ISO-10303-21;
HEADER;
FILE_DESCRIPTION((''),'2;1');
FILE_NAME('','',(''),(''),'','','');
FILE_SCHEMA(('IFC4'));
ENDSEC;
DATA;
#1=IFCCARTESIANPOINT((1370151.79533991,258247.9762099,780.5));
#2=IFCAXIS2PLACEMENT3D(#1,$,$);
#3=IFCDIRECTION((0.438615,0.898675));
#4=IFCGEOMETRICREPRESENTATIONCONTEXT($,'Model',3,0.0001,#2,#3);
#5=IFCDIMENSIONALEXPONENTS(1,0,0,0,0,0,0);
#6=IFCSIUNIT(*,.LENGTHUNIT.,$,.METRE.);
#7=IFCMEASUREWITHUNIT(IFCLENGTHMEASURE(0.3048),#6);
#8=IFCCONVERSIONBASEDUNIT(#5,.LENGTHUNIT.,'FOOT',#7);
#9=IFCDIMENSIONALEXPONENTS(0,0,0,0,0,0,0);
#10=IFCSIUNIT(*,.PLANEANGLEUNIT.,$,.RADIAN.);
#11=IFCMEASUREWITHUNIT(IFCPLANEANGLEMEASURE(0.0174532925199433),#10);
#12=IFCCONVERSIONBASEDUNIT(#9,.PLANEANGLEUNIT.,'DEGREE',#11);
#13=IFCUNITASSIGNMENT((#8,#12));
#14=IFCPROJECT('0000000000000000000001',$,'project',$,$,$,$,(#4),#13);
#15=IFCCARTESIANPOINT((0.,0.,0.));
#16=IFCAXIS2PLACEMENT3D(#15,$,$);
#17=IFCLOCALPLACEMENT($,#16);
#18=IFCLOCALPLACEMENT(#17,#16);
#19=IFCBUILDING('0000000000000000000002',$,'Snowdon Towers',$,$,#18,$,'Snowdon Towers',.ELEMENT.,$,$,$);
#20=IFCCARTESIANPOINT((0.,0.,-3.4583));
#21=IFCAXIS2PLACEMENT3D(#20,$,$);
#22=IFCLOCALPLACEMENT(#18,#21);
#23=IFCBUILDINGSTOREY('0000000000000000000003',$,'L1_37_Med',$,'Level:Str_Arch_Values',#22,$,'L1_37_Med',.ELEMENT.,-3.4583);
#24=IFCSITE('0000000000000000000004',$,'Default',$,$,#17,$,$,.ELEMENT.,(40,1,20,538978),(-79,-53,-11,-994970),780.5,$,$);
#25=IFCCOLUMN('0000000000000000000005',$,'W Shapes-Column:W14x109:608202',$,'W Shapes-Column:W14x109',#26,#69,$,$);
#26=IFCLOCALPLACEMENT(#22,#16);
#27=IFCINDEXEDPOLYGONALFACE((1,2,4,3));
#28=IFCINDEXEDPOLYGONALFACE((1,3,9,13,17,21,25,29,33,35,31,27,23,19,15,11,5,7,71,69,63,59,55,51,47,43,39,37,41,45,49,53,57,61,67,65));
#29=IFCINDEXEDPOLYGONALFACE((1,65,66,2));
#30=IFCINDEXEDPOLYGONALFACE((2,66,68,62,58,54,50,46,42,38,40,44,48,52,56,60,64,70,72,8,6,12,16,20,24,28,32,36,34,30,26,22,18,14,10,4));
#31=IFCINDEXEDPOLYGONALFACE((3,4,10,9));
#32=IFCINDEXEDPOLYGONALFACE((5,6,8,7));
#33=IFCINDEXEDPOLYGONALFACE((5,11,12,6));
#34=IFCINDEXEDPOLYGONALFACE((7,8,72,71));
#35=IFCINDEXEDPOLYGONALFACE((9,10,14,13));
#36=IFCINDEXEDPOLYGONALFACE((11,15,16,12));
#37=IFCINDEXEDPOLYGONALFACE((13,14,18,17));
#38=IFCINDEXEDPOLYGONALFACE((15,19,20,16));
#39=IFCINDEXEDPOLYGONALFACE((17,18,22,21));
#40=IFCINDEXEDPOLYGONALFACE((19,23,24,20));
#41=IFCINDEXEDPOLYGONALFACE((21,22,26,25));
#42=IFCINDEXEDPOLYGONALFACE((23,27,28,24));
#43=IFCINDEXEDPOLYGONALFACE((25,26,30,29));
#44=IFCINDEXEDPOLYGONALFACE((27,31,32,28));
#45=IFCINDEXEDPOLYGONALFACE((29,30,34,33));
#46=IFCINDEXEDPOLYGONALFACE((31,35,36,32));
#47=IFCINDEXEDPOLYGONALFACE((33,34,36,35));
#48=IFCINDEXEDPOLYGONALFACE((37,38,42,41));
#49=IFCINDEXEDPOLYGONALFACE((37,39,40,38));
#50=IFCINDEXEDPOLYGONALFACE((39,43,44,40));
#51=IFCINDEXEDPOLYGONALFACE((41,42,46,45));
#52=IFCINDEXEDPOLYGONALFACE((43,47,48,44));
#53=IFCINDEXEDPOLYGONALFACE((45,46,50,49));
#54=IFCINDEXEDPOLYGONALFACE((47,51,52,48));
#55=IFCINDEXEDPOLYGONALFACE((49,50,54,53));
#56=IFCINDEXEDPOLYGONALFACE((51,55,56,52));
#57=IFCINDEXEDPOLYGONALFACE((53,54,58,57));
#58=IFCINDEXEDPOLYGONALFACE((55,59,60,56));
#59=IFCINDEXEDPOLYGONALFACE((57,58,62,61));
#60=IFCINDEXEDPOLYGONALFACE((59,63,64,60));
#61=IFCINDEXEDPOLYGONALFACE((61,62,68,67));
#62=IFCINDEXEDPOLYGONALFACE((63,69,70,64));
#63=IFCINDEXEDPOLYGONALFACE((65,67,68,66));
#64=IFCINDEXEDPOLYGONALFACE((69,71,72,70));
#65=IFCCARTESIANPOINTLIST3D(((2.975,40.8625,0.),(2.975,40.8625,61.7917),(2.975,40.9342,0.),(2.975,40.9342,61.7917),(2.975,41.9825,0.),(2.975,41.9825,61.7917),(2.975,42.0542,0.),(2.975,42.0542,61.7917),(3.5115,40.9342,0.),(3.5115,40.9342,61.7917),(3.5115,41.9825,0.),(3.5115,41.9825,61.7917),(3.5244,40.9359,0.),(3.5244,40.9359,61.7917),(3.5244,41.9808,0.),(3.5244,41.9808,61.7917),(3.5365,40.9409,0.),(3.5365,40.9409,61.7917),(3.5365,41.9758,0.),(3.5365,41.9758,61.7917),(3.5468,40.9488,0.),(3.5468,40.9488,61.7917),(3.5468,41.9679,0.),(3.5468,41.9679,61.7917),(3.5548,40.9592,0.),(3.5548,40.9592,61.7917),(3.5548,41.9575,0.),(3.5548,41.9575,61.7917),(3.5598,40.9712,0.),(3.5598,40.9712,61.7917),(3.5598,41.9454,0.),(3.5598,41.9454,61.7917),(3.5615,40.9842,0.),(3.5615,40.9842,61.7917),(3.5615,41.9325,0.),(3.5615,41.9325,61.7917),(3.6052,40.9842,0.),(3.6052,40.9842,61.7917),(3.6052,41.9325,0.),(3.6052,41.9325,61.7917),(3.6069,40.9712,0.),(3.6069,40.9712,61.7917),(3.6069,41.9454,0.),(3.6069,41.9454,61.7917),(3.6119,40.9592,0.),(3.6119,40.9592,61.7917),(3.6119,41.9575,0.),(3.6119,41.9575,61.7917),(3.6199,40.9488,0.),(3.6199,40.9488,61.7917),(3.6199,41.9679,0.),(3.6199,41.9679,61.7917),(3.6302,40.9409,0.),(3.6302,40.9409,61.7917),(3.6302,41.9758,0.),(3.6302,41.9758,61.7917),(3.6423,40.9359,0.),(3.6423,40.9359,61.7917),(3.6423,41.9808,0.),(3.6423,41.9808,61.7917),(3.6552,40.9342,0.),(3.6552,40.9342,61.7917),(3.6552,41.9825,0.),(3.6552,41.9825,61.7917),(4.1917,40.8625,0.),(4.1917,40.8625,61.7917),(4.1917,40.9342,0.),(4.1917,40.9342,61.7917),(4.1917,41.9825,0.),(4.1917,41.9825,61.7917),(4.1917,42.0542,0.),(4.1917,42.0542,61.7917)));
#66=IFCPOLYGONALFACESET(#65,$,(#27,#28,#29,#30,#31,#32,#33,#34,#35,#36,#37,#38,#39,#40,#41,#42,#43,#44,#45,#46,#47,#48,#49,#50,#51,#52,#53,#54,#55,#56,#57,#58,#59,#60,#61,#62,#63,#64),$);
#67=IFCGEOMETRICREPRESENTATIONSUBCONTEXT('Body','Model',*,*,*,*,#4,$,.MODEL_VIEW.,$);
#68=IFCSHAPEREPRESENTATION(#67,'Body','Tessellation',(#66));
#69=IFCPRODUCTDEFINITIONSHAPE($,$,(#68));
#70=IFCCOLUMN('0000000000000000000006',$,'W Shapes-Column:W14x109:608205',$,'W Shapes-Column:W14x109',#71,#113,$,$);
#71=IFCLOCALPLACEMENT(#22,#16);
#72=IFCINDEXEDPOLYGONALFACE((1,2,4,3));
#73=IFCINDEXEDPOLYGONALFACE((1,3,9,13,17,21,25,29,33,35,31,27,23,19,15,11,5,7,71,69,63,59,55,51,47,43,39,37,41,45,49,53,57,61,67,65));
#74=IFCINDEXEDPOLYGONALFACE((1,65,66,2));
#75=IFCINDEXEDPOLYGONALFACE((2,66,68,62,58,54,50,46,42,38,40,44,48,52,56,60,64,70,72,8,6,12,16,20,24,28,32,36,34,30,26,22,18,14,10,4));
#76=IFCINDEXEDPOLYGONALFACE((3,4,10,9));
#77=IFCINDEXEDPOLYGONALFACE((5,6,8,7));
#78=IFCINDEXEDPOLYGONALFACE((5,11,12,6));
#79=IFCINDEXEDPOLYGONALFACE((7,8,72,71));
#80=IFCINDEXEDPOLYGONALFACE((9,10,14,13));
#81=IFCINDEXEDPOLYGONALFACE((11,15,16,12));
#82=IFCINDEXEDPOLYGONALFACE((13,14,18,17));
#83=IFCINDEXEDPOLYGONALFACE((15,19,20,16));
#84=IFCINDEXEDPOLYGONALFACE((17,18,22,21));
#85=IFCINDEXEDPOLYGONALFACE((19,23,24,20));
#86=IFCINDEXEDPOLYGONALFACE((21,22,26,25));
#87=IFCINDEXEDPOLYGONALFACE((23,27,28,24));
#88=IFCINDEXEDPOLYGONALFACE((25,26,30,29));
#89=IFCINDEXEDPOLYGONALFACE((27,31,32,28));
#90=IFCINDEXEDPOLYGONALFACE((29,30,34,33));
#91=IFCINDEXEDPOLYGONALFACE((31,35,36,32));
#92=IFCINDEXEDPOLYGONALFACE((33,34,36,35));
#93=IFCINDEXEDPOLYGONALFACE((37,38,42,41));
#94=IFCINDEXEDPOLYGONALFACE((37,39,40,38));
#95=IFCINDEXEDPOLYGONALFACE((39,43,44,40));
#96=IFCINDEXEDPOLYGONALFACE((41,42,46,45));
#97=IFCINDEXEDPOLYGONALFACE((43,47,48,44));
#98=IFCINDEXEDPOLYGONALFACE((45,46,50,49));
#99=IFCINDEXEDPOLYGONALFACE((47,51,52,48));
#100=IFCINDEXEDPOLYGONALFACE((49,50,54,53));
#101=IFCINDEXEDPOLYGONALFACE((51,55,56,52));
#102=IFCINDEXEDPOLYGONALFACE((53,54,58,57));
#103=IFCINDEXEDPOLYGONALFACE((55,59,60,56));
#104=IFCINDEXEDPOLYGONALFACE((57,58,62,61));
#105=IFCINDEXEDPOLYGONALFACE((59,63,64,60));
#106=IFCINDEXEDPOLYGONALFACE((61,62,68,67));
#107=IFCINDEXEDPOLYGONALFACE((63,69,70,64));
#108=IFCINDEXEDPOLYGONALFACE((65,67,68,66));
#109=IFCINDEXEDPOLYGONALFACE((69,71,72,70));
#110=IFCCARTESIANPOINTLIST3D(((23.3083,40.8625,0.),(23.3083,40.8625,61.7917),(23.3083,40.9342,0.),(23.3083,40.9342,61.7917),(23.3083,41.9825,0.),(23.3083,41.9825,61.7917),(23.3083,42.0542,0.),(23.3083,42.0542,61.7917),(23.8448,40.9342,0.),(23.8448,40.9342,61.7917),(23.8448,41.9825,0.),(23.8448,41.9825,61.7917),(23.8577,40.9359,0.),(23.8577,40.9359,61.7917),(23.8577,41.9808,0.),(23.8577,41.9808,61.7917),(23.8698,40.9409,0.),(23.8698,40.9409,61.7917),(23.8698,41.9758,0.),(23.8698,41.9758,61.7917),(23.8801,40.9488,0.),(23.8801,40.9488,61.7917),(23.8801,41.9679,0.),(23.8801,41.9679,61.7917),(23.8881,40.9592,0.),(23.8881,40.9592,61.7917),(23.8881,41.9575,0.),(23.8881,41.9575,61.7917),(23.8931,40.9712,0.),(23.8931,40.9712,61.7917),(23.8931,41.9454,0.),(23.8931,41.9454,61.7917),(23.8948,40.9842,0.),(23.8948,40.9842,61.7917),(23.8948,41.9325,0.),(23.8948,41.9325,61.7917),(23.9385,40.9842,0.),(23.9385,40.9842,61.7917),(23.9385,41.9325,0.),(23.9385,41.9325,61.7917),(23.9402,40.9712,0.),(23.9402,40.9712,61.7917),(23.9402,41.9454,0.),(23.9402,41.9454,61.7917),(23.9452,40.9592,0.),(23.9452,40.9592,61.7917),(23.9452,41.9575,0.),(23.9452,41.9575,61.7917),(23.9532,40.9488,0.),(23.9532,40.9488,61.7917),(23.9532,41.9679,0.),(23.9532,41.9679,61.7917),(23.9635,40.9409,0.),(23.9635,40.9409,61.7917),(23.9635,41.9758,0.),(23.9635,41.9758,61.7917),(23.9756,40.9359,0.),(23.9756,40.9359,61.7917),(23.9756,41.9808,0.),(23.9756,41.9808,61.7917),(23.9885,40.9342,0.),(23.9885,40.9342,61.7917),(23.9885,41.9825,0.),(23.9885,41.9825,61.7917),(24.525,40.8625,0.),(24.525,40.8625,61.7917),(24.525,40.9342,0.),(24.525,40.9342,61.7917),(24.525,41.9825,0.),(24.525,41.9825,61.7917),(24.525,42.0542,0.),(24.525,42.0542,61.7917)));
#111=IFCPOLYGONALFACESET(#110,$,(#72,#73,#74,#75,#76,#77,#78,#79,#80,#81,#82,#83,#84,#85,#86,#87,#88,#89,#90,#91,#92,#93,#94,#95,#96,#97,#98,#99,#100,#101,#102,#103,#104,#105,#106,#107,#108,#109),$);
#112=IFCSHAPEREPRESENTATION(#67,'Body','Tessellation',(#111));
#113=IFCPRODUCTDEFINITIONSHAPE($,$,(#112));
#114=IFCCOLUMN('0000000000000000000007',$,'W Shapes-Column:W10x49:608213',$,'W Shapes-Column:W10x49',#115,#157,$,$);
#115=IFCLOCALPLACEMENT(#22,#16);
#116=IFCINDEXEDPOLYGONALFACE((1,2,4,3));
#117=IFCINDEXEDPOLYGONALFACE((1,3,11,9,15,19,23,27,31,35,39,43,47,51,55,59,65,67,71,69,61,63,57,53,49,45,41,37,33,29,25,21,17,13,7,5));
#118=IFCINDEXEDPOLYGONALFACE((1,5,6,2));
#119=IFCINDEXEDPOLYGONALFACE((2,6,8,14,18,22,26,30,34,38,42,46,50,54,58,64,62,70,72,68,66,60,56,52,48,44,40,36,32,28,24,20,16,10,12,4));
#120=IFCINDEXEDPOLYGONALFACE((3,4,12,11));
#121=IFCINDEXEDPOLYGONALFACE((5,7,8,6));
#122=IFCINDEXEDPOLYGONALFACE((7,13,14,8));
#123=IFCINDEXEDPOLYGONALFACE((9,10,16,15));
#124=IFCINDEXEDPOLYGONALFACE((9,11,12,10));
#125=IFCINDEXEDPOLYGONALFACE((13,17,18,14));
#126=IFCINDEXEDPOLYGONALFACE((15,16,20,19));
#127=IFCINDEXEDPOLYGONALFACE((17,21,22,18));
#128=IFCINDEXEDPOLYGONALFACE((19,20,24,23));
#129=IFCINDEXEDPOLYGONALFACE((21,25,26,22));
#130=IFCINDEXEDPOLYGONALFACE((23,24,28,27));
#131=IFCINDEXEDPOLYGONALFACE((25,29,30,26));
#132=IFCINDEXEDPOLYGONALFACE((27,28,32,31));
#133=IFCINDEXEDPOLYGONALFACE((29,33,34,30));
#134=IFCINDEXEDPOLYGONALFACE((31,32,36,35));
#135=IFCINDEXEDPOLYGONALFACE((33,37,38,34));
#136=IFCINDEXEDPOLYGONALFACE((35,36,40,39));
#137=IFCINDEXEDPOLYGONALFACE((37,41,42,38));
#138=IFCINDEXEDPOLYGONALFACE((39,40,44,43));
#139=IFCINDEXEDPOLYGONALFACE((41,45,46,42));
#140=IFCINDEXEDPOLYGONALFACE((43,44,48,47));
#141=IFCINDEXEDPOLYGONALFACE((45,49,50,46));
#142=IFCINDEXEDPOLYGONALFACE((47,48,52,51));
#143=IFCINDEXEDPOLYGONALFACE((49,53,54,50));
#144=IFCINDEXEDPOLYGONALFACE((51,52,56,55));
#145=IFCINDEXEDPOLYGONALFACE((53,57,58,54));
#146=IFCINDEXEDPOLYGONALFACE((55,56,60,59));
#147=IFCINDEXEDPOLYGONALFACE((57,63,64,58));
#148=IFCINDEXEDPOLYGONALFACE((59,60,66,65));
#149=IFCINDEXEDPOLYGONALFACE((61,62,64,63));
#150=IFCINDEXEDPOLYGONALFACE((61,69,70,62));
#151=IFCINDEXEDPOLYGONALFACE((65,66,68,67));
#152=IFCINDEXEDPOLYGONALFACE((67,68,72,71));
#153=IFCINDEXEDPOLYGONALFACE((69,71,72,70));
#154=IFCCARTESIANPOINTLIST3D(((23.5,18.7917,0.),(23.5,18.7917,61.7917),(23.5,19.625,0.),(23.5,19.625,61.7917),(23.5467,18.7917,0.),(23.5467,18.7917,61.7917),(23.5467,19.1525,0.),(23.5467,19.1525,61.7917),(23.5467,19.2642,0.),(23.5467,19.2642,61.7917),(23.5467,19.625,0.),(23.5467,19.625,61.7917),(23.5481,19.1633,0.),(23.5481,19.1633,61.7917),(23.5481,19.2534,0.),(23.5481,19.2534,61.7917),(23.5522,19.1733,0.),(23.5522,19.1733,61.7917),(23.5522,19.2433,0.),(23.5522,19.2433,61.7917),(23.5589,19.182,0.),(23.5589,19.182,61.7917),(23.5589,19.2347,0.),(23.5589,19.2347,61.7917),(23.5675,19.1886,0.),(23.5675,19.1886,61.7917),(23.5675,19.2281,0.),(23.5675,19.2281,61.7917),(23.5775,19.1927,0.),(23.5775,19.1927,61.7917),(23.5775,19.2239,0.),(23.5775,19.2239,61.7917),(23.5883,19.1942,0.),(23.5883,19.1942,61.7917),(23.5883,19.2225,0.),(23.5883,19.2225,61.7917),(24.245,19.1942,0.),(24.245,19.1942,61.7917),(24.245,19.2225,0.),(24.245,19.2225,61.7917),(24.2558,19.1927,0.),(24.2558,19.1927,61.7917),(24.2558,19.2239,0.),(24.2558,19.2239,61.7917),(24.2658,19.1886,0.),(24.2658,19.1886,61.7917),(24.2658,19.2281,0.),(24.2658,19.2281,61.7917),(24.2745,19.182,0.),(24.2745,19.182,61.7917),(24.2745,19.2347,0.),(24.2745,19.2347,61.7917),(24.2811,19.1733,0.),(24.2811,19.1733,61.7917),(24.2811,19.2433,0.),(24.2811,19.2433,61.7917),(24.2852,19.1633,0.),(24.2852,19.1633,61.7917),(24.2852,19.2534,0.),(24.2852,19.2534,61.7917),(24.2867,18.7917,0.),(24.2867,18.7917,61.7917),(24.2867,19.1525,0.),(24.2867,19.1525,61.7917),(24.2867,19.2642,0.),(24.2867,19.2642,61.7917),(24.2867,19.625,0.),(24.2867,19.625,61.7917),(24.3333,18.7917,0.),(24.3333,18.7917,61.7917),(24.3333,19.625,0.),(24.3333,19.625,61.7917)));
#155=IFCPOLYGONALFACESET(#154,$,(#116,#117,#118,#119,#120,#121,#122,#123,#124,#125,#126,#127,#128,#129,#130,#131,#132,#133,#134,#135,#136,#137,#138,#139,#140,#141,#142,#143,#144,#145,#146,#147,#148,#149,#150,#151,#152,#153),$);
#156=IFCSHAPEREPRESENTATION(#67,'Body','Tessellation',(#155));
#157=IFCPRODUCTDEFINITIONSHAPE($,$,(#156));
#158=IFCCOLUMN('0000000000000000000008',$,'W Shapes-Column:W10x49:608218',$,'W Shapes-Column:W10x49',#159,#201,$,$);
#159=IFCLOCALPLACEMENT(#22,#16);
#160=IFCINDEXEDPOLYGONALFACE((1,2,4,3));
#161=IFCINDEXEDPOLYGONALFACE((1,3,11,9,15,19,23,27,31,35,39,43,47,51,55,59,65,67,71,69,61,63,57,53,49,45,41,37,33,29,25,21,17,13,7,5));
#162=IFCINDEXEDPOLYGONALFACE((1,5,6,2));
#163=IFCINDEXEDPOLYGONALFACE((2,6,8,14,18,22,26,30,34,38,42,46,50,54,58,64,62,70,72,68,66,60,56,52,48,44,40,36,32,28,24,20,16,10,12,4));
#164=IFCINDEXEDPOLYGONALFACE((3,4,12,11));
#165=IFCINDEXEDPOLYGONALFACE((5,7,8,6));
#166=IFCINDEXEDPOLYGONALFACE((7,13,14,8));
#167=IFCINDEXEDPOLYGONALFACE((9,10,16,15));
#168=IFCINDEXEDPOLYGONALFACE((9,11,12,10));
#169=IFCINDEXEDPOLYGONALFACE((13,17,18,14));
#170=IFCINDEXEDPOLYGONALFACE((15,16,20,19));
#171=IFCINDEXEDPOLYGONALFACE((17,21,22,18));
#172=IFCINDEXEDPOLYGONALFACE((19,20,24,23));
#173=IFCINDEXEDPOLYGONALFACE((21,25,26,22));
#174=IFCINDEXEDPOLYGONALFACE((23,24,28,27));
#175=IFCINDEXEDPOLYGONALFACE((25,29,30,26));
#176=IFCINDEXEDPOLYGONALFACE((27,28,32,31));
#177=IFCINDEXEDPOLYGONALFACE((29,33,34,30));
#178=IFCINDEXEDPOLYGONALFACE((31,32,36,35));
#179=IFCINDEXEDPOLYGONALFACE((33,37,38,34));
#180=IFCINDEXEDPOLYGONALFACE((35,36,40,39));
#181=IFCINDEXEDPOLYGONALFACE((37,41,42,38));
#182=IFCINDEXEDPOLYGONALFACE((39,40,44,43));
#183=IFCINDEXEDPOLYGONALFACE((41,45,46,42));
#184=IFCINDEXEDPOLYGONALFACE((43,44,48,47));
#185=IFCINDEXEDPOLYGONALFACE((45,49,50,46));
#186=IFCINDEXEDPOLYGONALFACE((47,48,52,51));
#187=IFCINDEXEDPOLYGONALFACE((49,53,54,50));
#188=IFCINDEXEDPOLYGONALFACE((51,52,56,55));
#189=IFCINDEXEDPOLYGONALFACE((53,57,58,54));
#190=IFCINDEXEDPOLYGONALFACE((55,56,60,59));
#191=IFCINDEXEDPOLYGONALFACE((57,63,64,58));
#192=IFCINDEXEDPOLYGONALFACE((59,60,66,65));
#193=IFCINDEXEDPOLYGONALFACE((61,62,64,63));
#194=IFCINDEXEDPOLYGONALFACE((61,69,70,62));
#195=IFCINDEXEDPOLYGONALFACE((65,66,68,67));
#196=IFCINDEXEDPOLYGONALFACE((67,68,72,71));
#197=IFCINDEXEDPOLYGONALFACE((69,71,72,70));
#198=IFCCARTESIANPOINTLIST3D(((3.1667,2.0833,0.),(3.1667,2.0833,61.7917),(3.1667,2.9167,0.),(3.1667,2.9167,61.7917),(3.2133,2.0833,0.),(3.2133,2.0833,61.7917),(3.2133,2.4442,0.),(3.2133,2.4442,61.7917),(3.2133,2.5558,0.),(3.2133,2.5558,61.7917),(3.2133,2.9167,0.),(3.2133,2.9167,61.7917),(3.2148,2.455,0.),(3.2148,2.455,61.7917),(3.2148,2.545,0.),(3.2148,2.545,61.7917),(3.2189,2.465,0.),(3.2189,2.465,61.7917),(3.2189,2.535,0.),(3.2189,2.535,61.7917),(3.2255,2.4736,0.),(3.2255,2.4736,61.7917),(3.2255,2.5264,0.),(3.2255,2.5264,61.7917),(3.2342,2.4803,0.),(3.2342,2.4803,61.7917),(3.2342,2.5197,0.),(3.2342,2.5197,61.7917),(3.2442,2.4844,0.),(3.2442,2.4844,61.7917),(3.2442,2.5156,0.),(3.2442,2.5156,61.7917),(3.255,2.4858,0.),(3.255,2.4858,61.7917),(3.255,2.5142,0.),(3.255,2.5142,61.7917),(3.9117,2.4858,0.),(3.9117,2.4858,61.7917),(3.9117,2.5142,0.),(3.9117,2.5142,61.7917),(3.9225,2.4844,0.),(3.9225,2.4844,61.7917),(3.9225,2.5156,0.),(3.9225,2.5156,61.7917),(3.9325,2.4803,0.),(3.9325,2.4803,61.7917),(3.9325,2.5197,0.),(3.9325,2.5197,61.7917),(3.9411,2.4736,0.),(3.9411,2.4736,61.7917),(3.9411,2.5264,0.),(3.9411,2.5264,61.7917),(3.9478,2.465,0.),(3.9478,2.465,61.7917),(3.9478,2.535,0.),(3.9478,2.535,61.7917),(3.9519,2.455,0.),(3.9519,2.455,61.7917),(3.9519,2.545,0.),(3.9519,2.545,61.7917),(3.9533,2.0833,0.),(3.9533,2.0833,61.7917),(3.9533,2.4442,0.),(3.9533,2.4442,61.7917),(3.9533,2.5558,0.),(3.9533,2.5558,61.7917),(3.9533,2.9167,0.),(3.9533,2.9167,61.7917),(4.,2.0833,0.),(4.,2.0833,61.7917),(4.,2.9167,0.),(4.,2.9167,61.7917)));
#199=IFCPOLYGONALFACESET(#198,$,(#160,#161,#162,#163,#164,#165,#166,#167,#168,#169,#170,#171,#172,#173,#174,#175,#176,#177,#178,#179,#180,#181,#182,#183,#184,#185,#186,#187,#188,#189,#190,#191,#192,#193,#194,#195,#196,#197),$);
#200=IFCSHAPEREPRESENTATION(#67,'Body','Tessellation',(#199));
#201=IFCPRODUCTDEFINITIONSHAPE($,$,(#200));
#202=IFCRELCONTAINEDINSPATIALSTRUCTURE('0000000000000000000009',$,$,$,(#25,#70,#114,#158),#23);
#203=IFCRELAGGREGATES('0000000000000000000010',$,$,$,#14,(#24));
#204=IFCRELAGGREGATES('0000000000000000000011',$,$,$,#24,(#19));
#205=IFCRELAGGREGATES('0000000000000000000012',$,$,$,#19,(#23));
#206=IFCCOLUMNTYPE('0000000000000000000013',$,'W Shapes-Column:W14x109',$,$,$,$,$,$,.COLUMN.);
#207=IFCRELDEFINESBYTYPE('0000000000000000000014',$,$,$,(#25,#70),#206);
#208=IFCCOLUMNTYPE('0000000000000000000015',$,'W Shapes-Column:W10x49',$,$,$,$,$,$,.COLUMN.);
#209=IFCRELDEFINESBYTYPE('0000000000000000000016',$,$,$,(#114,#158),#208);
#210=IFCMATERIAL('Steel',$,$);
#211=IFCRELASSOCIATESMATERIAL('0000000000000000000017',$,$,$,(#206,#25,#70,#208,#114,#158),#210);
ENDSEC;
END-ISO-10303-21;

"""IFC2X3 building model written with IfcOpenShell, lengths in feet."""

from ifc_helpers import new_model, entity, si_unit, converted_unit, direction, frame, frame_2d, origin, place, context, subcontext, project, spatial, i_section, extrude, source, transform, mapped, material, type_object, type_shapes, element, save


model = new_model("IFC2X3")

# Units and contexts
model_context = context("Model", 3, precision=0.0001, world=frame((1370151.79533991, 258247.9762099, 780.5)), true_north=direction((0.438615, 0.898675)))
body_context = subcontext(model_context, "Body", "Model", "MODEL_VIEW")
ifc_project = project(units=[converted_unit("LENGTHUNIT", "FOOT", entity("IfcLengthMeasure", 0.3048), si_unit("LENGTHUNIT", "METRE"), dimensions=[1, 0, 0, 0, 0, 0, 0]), converted_unit("PLANEANGLEUNIT", "DEGREE", entity("IfcPlaneAngleMeasure", 0.0174532925199433), si_unit("PLANEANGLEUNIT", "RADIAN"), dimensions=[0, 0, 0, 0, 0, 0, 0])], contexts=[model_context])

# Site, building, storey
site_placement = place(None, origin())
site = spatial("IfcSite", under=ifc_project, at=site_placement, Name="Default", CompositionType="ELEMENT", RefLatitude=(40, 1, 20, 538978), RefLongitude=(-79, -53, -11, -994970), RefElevation=780.5)
building_placement = place(site_placement, origin())
building = spatial("IfcBuilding", under=site, at=building_placement, Name="Snowdon Towers", LongName="Snowdon Towers", CompositionType="ELEMENT")
storey_placement = place(building_placement, frame((0.0, 0.0, -3.4583)))
storey = spatial("IfcBuildingStorey", under=building, at=storey_placement, Name="L1_37_Med", ObjectType="Level:Str_Arch_Values", LongName="L1_37_Med", CompositionType="ELEMENT", Elevation=-3.4583)

# Columns
ifc_material_1 = material(Name="Steel")
column_type_1 = type_object("IfcColumnType", Name="W Shapes-Column:W14x109", PredefinedType="COLUMN", material=ifc_material_1)
shared_shape_1 = source(origin(), body_context, "Body", "SweptSolid", [
    extrude(i_section(OverallWidth=1.2167, OverallDepth=1.1917, WebThickness=0.0438, FlangeThickness=0.0717, FilletRadius=0.05, at=frame_2d((0.0, 0.0), x_axis=(1.0, 0.0))), frame((0.0, 0.0, -3.4583), z_axis=(0.0, 0.0, 1.0), x_axis=(-1.0, 0.0, 0.0)), (0.0, 0.0, 1.0), 61.7917),
])
type_shapes(column_type_1, [shared_shape_1])
column_1_placement = place(storey_placement, frame((3.5833, 41.4583, 3.4583), z_axis=(0.0, 0.0, 1.0), x_axis=(-1.0, 0.0, 0.0)))
element("IfcColumn", 1, at=column_1_placement, inside=storey, type_object=column_type_1, material=ifc_material_1, Name="W Shapes-Column:W14x109:608202", ObjectType="W Shapes-Column:W14x109", context=body_context, shape_type="MappedRepresentation", body=[
    mapped(shared_shape_1, transform((0.0, 0.0, 0.0), scale=1.0)),
])
column_2_placement = place(storey_placement, frame((23.9167, 41.4583, 3.4583)))
element("IfcColumn", 2, at=column_2_placement, inside=storey, type_object=column_type_1, material=ifc_material_1, Name="W Shapes-Column:W14x109:608205", ObjectType="W Shapes-Column:W14x109", context=body_context, shape_type="MappedRepresentation", body=[
    mapped(shared_shape_1, transform((0.0, 0.0, 0.0), scale=1.0)),
])
column_type_2 = type_object("IfcColumnType", Name="W Shapes-Column:W10x49", PredefinedType="COLUMN", material=ifc_material_1)
shared_shape_2 = source(origin(), body_context, "Body", "SweptSolid", [
    extrude(i_section(OverallWidth=0.8333, OverallDepth=0.8333, WebThickness=0.0283, FlangeThickness=0.0467, FilletRadius=0.0417, at=frame_2d((0.0, 0.0), x_axis=(1.0, 0.0))), frame((0.0, 0.0, -3.4583), z_axis=(0.0, 0.0, 1.0), x_axis=(-1.0, 0.0, 0.0)), (0.0, 0.0, 1.0), 61.7917),
])
type_shapes(column_type_2, [shared_shape_2])
for number, where, z_axis, x_axis, name in (
    (3, (23.9167, 19.2083, 3.4583), (0.0, 0.0, 1.0), (0.0, 1.0, 0.0), "W Shapes-Column:W10x49:608213"),
    (4, (3.5833, 2.5, 3.4583), (0.0, 0.0, 1.0), (0.0, 1.0, 0.0), "W Shapes-Column:W10x49:608218"),
):
    element("IfcColumn", number, at=place(storey_placement, frame(where, z_axis=z_axis, x_axis=x_axis)), inside=storey, type_object=column_type_2, material=ifc_material_1, Name=name, ObjectType="W Shapes-Column:W10x49", context=body_context, shape_type="MappedRepresentation", body=[
        mapped(shared_shape_2, transform((0.0, 0.0, 0.0), scale=1.0)),
    ])

save(model, "model.ifc")
